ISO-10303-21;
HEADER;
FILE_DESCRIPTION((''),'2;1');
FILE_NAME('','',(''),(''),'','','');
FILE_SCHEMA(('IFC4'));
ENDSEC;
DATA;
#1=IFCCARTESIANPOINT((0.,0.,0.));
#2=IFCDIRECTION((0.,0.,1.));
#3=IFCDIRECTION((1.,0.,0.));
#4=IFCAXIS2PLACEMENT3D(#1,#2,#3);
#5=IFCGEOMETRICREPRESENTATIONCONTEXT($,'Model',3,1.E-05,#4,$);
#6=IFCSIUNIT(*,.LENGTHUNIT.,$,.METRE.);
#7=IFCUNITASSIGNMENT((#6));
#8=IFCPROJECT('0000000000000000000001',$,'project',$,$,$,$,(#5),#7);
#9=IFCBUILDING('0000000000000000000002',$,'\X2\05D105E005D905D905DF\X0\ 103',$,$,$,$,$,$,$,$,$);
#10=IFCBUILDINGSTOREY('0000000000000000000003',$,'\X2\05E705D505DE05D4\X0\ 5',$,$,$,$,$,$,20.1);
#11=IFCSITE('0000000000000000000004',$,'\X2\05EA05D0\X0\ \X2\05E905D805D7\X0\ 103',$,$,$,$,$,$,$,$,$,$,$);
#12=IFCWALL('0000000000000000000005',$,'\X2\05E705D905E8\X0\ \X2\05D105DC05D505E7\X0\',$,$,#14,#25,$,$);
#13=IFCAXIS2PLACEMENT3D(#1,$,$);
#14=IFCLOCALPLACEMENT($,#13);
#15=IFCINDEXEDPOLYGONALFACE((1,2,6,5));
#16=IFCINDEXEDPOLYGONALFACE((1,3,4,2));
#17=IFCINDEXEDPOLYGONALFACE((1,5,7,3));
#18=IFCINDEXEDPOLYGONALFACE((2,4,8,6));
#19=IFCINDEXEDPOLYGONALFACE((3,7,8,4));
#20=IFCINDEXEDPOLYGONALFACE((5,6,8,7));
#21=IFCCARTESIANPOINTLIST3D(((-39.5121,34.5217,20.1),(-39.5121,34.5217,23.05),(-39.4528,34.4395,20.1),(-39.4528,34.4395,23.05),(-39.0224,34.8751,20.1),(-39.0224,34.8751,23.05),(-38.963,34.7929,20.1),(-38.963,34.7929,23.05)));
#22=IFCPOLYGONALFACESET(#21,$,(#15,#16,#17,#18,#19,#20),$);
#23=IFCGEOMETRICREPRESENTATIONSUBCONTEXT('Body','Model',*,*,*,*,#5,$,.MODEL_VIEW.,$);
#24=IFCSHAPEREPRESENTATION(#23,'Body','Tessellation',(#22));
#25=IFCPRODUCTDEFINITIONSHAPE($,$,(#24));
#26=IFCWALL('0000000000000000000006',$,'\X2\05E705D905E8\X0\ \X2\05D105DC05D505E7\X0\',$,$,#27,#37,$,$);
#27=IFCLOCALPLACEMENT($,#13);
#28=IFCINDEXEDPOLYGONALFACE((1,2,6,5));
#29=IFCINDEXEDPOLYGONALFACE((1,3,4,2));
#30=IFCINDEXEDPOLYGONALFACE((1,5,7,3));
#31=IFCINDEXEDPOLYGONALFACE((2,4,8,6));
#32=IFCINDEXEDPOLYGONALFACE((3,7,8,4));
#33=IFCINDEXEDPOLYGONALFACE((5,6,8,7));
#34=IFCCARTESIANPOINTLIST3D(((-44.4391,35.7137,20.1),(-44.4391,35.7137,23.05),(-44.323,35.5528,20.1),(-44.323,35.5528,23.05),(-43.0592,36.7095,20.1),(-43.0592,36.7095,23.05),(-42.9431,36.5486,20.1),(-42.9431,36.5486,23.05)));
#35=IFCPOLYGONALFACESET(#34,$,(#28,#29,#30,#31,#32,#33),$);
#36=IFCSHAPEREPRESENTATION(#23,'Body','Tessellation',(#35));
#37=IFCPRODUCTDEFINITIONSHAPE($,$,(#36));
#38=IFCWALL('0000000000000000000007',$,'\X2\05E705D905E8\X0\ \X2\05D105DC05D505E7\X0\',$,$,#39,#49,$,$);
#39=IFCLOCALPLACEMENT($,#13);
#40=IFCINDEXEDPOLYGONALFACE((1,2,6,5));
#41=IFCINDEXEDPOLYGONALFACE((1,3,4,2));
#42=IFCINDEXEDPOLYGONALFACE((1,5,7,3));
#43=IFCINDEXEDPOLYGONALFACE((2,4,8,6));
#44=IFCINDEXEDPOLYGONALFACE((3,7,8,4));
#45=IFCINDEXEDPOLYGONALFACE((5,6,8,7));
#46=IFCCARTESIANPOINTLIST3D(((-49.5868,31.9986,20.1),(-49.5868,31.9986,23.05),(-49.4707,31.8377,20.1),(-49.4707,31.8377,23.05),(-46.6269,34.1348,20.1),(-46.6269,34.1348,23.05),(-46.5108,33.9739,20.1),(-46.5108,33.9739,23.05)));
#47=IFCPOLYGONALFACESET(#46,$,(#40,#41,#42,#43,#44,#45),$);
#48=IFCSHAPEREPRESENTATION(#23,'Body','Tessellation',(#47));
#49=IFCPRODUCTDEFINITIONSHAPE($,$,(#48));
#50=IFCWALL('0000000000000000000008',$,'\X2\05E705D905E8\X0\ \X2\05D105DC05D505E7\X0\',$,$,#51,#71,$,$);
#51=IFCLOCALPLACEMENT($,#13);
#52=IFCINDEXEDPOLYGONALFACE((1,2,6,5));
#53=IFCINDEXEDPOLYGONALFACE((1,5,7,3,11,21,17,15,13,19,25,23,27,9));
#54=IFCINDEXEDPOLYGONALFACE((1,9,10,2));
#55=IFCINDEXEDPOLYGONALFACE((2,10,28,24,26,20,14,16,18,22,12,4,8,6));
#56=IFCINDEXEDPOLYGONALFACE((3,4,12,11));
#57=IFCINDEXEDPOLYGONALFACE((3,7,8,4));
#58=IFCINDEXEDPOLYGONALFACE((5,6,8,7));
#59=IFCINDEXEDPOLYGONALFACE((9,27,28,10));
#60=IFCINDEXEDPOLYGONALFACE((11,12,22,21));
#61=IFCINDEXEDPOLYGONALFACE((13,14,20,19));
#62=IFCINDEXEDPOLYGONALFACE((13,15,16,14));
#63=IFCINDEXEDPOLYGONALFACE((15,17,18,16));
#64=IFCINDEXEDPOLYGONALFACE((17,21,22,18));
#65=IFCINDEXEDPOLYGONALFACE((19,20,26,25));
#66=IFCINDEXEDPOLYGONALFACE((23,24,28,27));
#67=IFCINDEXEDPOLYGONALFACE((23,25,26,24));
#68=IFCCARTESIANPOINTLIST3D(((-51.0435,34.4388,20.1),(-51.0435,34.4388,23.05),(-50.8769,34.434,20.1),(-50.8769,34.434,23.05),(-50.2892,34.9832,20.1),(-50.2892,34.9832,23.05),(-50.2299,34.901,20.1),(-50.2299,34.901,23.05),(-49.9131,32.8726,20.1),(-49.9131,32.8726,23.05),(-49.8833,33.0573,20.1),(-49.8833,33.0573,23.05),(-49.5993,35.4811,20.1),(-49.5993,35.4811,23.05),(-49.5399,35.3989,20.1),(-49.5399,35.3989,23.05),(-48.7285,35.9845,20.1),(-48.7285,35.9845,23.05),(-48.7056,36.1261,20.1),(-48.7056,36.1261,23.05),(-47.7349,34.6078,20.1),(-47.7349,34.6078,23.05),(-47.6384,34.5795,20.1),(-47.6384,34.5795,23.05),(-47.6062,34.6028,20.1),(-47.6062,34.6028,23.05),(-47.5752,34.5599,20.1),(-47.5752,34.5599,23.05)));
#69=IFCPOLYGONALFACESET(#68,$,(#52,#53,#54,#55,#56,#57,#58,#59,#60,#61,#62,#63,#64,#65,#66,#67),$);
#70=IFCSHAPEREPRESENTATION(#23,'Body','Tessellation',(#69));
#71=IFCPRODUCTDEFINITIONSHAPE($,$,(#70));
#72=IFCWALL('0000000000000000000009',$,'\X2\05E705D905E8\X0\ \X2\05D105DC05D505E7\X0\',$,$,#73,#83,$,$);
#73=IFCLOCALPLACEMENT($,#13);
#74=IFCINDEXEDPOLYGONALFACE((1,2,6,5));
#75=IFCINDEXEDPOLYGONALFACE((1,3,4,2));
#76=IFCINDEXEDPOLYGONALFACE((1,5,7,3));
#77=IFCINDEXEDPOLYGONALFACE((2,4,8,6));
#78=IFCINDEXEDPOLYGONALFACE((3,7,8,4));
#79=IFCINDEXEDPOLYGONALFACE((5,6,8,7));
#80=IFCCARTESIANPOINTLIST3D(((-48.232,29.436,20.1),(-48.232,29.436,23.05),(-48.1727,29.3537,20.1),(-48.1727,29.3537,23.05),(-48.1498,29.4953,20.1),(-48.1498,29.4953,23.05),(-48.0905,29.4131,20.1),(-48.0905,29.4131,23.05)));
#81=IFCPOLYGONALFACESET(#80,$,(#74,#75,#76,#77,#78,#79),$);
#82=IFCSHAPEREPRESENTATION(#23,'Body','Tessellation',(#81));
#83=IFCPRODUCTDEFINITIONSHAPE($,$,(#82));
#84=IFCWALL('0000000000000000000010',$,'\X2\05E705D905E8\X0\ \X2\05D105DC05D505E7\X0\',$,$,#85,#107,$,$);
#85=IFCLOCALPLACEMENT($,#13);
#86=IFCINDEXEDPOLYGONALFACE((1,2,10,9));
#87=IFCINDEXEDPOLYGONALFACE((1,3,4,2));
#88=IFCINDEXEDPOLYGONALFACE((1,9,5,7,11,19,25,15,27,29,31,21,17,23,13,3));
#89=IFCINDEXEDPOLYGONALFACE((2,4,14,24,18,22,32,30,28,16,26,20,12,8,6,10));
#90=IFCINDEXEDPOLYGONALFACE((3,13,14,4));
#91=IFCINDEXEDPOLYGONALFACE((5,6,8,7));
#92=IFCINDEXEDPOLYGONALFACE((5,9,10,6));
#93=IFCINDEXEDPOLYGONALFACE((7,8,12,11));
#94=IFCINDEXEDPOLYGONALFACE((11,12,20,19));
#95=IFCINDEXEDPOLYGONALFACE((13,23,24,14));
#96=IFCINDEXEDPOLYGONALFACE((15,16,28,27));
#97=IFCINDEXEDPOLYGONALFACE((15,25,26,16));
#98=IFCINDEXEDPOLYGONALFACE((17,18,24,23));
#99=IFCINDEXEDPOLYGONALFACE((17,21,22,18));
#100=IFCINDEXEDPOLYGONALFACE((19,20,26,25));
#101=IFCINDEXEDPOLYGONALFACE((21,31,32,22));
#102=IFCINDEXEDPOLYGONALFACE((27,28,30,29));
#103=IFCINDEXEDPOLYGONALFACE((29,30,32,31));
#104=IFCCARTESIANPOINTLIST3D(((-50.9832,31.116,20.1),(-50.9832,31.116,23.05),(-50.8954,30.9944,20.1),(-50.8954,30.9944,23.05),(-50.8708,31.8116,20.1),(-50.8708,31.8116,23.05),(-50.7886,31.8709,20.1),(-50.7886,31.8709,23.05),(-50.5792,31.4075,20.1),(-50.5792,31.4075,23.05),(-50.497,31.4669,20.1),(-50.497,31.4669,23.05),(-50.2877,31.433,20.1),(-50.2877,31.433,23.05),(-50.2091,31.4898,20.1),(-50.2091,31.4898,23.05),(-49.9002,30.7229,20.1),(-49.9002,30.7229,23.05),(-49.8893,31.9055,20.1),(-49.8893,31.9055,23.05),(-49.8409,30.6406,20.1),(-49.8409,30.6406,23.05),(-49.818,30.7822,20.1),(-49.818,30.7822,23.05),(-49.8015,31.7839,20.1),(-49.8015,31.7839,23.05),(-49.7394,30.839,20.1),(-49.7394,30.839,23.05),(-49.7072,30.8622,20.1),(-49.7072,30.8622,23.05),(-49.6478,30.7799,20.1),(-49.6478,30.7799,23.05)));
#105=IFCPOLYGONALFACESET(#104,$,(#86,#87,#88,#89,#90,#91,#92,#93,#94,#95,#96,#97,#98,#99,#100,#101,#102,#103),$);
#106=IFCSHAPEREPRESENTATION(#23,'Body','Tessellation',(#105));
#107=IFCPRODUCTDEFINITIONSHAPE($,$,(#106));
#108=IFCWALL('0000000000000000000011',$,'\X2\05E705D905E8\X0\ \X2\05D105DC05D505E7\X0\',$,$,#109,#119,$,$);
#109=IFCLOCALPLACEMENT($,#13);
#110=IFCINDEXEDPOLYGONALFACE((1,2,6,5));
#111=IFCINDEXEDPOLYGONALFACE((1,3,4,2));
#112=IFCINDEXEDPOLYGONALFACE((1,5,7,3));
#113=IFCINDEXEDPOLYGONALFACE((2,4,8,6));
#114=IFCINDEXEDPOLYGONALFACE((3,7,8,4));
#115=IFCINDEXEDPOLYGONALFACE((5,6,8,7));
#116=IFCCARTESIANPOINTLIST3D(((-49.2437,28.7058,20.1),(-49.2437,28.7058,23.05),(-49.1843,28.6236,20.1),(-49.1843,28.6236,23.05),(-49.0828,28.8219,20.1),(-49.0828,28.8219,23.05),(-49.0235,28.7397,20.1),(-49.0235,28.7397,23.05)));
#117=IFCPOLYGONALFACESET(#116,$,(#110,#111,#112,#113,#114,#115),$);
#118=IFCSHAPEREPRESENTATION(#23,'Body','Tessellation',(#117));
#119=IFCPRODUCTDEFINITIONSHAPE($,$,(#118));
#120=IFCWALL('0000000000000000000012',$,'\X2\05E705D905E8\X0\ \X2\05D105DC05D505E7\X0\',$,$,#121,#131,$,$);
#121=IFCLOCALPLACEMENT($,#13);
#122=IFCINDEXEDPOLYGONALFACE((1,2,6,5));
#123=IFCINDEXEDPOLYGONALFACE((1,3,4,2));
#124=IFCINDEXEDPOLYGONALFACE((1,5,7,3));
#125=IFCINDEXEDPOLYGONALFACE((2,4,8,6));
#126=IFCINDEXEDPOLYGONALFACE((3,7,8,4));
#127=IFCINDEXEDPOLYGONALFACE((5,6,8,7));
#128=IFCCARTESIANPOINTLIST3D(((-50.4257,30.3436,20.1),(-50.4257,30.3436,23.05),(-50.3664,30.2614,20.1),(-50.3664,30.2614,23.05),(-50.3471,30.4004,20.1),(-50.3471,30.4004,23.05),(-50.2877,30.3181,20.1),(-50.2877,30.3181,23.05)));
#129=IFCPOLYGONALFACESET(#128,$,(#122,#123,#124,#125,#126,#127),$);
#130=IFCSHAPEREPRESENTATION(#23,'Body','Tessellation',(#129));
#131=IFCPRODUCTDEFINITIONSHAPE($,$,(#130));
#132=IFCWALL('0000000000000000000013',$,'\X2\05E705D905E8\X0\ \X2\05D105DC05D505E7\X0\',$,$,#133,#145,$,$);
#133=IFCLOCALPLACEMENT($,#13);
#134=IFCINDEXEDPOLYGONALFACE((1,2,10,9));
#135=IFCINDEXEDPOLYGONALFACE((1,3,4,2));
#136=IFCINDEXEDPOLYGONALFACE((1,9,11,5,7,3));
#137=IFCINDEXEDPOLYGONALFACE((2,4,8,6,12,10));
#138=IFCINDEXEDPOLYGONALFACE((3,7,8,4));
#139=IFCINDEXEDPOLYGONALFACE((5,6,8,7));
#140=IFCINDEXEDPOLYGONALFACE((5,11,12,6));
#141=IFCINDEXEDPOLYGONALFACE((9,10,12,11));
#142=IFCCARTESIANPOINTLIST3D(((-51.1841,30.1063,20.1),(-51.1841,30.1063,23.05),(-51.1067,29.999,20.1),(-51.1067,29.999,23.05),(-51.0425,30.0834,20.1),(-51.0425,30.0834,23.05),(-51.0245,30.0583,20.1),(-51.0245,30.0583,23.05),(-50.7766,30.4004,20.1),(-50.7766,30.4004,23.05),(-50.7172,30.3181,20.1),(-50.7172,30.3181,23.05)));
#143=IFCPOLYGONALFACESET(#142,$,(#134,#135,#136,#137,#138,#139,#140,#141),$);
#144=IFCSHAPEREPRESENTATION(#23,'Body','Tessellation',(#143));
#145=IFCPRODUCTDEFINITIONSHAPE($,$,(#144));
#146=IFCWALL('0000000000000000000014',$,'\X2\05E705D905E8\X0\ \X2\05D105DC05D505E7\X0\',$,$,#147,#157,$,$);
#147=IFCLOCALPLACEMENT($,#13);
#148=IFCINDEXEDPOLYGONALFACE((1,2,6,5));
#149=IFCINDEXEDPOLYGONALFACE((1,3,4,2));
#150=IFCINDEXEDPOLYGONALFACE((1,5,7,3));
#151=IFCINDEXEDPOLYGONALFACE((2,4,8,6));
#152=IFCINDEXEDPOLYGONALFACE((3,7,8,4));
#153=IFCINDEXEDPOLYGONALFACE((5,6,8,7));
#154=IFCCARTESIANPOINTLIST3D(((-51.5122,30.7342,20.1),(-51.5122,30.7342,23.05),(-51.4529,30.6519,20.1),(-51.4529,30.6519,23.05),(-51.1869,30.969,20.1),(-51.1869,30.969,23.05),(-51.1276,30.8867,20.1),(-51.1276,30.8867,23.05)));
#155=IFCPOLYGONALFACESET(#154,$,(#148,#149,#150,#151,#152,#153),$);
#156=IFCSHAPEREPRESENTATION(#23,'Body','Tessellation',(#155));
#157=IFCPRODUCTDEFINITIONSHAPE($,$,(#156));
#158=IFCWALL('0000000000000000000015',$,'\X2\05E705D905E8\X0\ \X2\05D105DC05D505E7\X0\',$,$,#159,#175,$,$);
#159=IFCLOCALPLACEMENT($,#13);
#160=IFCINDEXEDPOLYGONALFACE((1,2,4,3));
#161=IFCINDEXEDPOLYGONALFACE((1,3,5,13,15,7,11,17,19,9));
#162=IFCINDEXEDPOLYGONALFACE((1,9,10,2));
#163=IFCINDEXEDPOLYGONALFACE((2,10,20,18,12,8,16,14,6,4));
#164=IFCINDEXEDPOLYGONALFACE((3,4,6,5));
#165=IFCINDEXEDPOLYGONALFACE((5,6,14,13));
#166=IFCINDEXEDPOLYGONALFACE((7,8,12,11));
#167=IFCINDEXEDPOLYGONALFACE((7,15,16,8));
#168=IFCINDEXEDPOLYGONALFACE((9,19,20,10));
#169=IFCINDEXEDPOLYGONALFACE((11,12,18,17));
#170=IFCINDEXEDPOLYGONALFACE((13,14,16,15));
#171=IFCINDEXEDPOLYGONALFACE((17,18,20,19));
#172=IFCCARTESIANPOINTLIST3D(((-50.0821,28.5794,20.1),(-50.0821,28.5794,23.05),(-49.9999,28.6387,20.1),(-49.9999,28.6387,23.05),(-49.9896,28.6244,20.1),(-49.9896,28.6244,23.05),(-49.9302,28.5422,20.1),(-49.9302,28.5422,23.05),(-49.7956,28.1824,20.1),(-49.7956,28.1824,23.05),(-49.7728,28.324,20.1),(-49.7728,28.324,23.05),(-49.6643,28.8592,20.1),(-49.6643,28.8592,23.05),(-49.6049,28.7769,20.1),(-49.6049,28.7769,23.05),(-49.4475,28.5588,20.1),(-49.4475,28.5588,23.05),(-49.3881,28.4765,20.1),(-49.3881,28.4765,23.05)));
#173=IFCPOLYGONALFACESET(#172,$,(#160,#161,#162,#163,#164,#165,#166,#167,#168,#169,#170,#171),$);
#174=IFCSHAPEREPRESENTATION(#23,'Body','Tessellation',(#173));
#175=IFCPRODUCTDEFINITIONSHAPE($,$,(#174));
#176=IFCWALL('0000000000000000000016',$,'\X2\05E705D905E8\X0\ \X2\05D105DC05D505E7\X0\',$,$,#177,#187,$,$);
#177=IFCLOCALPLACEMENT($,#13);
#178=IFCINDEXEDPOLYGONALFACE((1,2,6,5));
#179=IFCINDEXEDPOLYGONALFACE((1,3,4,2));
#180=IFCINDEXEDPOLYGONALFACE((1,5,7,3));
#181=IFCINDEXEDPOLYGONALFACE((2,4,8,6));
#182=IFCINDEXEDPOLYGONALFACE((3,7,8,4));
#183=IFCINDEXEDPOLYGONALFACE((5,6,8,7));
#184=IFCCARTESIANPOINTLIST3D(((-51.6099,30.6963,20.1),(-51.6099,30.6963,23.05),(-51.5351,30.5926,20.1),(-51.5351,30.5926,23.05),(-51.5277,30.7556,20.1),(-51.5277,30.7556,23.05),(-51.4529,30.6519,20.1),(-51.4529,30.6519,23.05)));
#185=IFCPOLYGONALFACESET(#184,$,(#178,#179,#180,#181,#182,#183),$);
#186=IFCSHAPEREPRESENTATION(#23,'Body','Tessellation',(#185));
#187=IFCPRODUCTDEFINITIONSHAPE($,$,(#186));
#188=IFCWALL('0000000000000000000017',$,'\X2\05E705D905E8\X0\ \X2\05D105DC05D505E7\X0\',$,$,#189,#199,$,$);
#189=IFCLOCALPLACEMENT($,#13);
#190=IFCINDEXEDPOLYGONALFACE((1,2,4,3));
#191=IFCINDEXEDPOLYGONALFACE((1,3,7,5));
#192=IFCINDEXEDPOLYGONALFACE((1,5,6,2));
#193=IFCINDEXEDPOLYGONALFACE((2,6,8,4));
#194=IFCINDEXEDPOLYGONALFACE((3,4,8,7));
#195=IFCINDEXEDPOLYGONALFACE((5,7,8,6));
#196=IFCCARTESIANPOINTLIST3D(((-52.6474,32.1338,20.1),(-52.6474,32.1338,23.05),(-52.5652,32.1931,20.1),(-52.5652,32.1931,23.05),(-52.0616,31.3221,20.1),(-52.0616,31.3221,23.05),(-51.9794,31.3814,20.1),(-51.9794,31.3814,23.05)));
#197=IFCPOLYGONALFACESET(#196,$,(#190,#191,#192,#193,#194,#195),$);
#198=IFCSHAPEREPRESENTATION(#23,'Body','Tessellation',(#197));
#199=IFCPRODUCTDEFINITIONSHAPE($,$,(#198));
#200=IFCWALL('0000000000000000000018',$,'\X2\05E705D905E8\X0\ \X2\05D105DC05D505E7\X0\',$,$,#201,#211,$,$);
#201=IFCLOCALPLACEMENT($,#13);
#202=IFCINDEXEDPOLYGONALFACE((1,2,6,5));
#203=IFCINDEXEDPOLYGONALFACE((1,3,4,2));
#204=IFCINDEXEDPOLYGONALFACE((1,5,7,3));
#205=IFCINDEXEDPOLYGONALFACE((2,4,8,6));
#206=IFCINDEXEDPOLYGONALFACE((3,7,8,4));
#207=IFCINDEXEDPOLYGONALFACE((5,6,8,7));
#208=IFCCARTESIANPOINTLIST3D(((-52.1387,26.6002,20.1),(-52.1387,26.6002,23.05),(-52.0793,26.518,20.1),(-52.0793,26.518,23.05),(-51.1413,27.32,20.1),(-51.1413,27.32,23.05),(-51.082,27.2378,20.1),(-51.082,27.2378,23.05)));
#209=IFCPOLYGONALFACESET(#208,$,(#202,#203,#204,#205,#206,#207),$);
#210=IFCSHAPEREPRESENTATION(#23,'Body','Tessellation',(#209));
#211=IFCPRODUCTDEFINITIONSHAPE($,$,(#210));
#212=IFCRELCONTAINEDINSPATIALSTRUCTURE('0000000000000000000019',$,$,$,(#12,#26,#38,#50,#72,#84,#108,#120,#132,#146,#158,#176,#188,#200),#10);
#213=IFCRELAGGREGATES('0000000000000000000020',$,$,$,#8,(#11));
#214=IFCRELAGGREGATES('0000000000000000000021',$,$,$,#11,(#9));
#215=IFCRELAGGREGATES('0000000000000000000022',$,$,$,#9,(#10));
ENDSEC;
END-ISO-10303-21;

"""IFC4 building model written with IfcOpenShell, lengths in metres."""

from ifc_helpers import new_model, si_unit, frame, origin_with_axes, context, subcontext, project, spatial, polyline, outline, extrude, element, save


model = new_model("IFC4")

# Units and contexts
model_context = context("Model", 3, precision=1e-05, world=origin_with_axes())
body_context = subcontext(model_context, "Body", "Model", "MODEL_VIEW")
ifc_project = project(units=[si_unit("LENGTHUNIT", "METRE")], contexts=[model_context])

# Site, building, storey
site = spatial("IfcSite", under=ifc_project, Name="תא שטח 103")
building = spatial("IfcBuilding", under=site, Name="בניין 103")
storey = spatial("IfcBuildingStorey", under=building, Name="קומה 5", Elevation=20.1)

# Walls
element("IfcWall", 1, inside=storey, Name="קיר בלוק", context=body_context, shape_type="SweptSolid", body=[
    extrude(outline(polyline([(-39.0224, 34.8751), (-38.963, 34.7929), (-39.4528, 34.4395), (-39.5121, 34.5217), (-39.0224, 34.8751)])), frame((0.0, 0.0, 20.1)), (0.0, 0.0, 1.0), 2.95),
])
element("IfcWall", 2, inside=storey, Name="קיר בלוק", context=body_context, shape_type="SweptSolid", body=[
    extrude(outline(polyline([(-44.323, 35.5528), (-44.4391, 35.7137), (-43.0592, 36.7095), (-42.9431, 36.5486), (-44.323, 35.5528)])), frame((0.0, 0.0, 20.1)), (0.0, 0.0, 1.0), 2.95),
])
element("IfcWall", 3, inside=storey, Name="קיר בלוק", context=body_context, shape_type="SweptSolid", body=[
    extrude(outline(polyline([(-49.4707, 31.8377), (-49.5868, 31.9986), (-46.6269, 34.1348), (-46.5108, 33.9739), (-49.4707, 31.8377)])), frame((0.0, 0.0, 20.1)), (0.0, 0.0, 1.0), 2.95),
])
element("IfcWall", 4, inside=storey, Name="קיר בלוק", context=body_context, shape_type="SweptSolid", body=[
    extrude(outline(polyline([(-49.9131, 32.8726), (-51.0435, 34.4388), (-50.2892, 34.9832), (-50.2299, 34.901), (-50.8769, 34.434), (-49.8833, 33.0573), (-47.7349, 34.6078), (-48.7285, 35.9845), (-49.5399, 35.3989), (-49.5993, 35.4811), (-48.7056, 36.1261), (-47.6062, 34.6028), (-47.6384, 34.5795), (-47.5752, 34.5599), (-49.9131, 32.8726)])), frame((0.0, 0.0, 20.1)), (0.0, 0.0, 1.0), 2.95),
])
element("IfcWall", 5, inside=storey, Name="קיר בלוק", context=body_context, shape_type="SweptSolid", body=[
    extrude(outline(polyline([(-48.1727, 29.3537), (-48.232, 29.436), (-48.1498, 29.4953), (-48.0905, 29.4131), (-48.1727, 29.3537)])), frame((0.0, 0.0, 20.1)), (0.0, 0.0, 1.0), 2.95),
])
element("IfcWall", 6, inside=storey, Name="קיר בלוק", context=body_context, shape_type="SweptSolid", body=[
    extrude(outline(polyline([(-49.9002, 30.7229), (-49.818, 30.7822), (-50.2877, 31.433), (-50.8954, 30.9944), (-50.9832, 31.116), (-50.5792, 31.4075), (-50.8708, 31.8116), (-50.7886, 31.8709), (-50.497, 31.4669), (-49.8893, 31.9055), (-49.8015, 31.7839), (-50.2091, 31.4898), (-49.7394, 30.839), (-49.7072, 30.8622), (-49.6478, 30.7799), (-49.8409, 30.6406), (-49.9002, 30.7229)])), frame((0.0, 0.0, 20.1)), (0.0, 0.0, 1.0), 2.95),
])
element("IfcWall", 7, inside=storey, Name="קיר בלוק", context=body_context, shape_type="SweptSolid", body=[
    extrude(outline(polyline([(-49.0828, 28.8219), (-49.0235, 28.7397), (-49.1843, 28.6236), (-49.2437, 28.7058), (-49.0828, 28.8219)])), frame((0.0, 0.0, 20.1)), (0.0, 0.0, 1.0), 2.95),
])
element("IfcWall", 8, inside=storey, Name="קיר בלוק", context=body_context, shape_type="SweptSolid", body=[
    extrude(outline(polyline([(-50.3471, 30.4004), (-50.2877, 30.3181), (-50.3664, 30.2614), (-50.4257, 30.3436), (-50.3471, 30.4004)])), frame((0.0, 0.0, 20.1)), (0.0, 0.0, 1.0), 2.95),
])
element("IfcWall", 9, inside=storey, Name="קיר בלוק", context=body_context, shape_type="SweptSolid", body=[
    extrude(outline(polyline([(-51.1067, 29.999), (-51.1841, 30.1063), (-50.7766, 30.4004), (-50.7172, 30.3181), (-51.0425, 30.0834), (-51.0245, 30.0583), (-51.1067, 29.999)])), frame((0.0, 0.0, 20.1)), (0.0, 0.0, 1.0), 2.95),
])
element("IfcWall", 10, inside=storey, Name="קיר בלוק", context=body_context, shape_type="SweptSolid", body=[
    extrude(outline(polyline([(-51.1276, 30.8867), (-51.4529, 30.6519), (-51.5122, 30.7342), (-51.1869, 30.969), (-51.1276, 30.8867)])), frame((0.0, 0.0, 20.1)), (0.0, 0.0, 1.0), 2.95),
])
element("IfcWall", 11, inside=storey, Name="קיר בלוק", context=body_context, shape_type="SweptSolid", body=[
    extrude(outline(polyline([(-49.9999, 28.6387), (-49.9896, 28.6244), (-49.6643, 28.8592), (-49.6049, 28.7769), (-49.9302, 28.5422), (-49.7728, 28.324), (-49.4475, 28.5588), (-49.3881, 28.4765), (-49.7956, 28.1824), (-50.0821, 28.5794), (-49.9999, 28.6387)])), frame((0.0, 0.0, 20.1)), (0.0, 0.0, 1.0), 2.95),
])
element("IfcWall", 12, inside=storey, Name="קיר בלוק", context=body_context, shape_type="SweptSolid", body=[
    extrude(outline(polyline([(-51.5277, 30.7556), (-51.4529, 30.6519), (-51.5351, 30.5926), (-51.6099, 30.6963), (-51.5277, 30.7556)])), frame((0.0, 0.0, 20.1)), (0.0, 0.0, 1.0), 2.95),
])
element("IfcWall", 13, inside=storey, Name="קיר בלוק", context=body_context, shape_type="SweptSolid", body=[
    extrude(outline(polyline([(-52.5652, 32.1931), (-51.9794, 31.3814), (-52.0616, 31.3221), (-52.6474, 32.1338), (-52.5652, 32.1931)])), frame((0.0, 0.0, 20.1)), (0.0, 0.0, 1.0), 2.95),
])
element("IfcWall", 14, inside=storey, Name="קיר בלוק", context=body_context, shape_type="SweptSolid", body=[
    extrude(outline(polyline([(-51.1413, 27.32), (-51.082, 27.2378), (-52.0793, 26.518), (-52.1387, 26.6002), (-51.1413, 27.32)])), frame((0.0, 0.0, 20.1)), (0.0, 0.0, 1.0), 2.95),
])

save(model, "model.ifc")
